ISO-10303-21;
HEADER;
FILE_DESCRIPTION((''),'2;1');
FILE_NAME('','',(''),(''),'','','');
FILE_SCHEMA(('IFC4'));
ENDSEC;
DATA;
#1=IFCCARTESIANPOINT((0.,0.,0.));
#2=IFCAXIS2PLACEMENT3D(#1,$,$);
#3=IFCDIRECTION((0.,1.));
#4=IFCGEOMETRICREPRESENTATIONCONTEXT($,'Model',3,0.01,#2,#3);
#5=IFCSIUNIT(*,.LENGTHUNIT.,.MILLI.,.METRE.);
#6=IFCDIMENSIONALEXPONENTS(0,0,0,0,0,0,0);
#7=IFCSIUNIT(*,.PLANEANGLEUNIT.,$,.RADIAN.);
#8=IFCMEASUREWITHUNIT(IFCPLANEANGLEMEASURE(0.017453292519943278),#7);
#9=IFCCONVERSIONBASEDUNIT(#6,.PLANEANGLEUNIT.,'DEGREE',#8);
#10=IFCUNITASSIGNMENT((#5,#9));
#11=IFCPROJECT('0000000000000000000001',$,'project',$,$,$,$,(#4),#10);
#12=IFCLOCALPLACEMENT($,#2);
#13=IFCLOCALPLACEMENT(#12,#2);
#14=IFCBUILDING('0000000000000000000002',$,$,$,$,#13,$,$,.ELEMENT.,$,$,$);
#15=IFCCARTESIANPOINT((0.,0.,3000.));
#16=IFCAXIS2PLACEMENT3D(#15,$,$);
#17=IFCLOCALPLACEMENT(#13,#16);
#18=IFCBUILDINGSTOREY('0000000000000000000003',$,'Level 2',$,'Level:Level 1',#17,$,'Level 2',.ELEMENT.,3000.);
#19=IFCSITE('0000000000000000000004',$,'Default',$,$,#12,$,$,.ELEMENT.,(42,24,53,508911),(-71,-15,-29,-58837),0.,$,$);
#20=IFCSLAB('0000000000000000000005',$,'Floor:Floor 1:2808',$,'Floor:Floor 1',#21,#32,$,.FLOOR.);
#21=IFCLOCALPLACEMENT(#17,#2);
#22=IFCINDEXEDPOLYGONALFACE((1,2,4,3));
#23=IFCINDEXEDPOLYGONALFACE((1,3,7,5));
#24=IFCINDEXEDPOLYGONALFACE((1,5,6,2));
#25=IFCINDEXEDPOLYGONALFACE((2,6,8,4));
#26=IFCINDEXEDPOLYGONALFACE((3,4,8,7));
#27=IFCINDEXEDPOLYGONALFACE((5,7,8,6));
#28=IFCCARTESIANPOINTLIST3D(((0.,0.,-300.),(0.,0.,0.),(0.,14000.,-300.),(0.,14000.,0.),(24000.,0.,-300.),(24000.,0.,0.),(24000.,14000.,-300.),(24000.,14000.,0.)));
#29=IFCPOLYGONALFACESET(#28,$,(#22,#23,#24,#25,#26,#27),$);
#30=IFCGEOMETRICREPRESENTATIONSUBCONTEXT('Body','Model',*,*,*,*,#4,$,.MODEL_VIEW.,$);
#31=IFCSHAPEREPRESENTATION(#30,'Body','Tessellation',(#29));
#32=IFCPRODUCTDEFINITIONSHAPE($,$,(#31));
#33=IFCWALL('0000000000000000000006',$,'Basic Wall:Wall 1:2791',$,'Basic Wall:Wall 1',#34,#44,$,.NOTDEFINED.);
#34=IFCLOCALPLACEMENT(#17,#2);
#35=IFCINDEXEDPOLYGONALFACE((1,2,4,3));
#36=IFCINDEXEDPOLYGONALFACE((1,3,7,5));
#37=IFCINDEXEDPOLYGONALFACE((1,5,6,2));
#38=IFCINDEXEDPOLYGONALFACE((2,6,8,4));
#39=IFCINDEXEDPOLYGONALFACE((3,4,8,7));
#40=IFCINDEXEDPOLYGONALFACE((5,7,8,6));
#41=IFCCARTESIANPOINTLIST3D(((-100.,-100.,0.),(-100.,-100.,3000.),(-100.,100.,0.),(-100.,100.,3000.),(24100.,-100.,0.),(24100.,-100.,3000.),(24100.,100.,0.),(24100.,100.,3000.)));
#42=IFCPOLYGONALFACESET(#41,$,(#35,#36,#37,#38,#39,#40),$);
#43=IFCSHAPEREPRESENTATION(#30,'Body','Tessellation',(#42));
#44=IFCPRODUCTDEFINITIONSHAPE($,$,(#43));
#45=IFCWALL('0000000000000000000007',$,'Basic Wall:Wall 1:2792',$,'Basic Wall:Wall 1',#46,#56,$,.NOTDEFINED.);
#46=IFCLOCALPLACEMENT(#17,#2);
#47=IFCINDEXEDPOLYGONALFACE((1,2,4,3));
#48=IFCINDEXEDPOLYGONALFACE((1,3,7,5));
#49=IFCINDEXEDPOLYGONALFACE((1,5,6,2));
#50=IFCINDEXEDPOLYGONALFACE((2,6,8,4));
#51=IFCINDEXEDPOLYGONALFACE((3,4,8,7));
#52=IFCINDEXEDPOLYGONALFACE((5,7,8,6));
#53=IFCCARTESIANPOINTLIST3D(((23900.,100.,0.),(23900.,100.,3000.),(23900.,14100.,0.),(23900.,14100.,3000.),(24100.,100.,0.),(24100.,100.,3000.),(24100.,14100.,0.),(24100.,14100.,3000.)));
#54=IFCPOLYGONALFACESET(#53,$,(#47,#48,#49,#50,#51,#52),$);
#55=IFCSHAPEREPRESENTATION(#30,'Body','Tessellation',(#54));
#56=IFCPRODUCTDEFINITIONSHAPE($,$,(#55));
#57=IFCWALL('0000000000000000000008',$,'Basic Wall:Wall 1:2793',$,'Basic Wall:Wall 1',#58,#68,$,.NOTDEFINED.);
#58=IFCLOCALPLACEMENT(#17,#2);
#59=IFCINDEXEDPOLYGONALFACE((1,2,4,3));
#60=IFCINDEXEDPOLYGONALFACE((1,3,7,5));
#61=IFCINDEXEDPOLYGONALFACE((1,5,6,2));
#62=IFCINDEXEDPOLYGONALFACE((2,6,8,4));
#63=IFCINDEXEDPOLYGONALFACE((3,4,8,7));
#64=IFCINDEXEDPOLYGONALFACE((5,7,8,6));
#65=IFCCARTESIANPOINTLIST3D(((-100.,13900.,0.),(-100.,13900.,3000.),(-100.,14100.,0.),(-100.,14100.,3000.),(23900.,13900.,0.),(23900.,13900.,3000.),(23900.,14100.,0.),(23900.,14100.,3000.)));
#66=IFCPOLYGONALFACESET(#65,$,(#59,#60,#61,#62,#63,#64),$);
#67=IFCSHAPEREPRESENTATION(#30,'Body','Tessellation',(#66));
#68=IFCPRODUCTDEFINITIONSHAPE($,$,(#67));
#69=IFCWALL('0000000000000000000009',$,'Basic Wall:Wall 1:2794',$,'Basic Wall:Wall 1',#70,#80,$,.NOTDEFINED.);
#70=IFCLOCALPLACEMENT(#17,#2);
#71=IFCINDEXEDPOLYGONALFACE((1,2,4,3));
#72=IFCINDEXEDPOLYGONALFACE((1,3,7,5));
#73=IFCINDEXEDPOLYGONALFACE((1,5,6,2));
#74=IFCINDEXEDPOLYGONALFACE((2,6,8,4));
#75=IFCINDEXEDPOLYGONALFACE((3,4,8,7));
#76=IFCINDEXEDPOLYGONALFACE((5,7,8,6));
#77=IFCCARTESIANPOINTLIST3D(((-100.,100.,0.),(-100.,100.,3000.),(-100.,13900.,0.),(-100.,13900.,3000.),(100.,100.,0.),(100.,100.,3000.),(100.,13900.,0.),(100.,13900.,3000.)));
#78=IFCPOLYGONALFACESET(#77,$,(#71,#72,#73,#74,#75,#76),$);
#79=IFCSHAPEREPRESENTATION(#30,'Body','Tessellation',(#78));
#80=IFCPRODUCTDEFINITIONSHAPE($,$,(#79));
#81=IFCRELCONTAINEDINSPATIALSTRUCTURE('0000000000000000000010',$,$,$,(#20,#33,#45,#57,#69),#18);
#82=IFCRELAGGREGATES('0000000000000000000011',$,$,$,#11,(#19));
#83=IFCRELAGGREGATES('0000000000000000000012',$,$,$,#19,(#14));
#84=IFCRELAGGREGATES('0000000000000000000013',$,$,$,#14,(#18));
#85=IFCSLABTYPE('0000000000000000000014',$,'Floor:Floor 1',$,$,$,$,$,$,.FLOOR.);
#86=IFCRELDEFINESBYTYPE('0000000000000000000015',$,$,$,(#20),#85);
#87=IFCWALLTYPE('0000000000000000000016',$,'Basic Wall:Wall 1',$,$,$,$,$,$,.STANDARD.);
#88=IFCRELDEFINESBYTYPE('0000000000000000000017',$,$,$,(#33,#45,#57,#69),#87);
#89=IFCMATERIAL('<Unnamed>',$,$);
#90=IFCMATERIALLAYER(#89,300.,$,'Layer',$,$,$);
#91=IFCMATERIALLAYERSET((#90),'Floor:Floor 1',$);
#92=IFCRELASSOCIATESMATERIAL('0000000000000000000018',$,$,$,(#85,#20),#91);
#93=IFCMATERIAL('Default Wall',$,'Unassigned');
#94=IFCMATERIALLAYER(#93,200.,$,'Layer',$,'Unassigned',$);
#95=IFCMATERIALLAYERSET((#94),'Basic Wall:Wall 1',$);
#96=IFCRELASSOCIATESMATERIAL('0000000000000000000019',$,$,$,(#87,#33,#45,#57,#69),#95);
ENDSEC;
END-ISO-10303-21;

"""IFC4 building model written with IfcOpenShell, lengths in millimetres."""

from ifc_helpers import new_model, entity, si_unit, converted_unit, direction, frame, frame_2d, origin, origin_2d_with_axis, place, context, subcontext, project, spatial, rectangle, extrude, material, layer, layer_set, layer_usage, type_object, element, save


model = new_model("IFC4")

# Units and contexts
model_context = context("Model", 3, precision=0.01, world=origin(), true_north=direction((0.0, 1.0)))
body_context = subcontext(model_context, "Body", "Model", "MODEL_VIEW")
ifc_project = project(units=[si_unit("LENGTHUNIT", "METRE", prefix="MILLI"), converted_unit("PLANEANGLEUNIT", "DEGREE", entity("IfcPlaneAngleMeasure", 0.017453292519943278), si_unit("PLANEANGLEUNIT", "RADIAN"), dimensions=[0, 0, 0, 0, 0, 0, 0])], contexts=[model_context])

# Site, building, storey
site_placement = place(None, origin())
site = spatial("IfcSite", under=ifc_project, at=site_placement, Name="Default", CompositionType="ELEMENT", RefLatitude=(42, 24, 53, 508911), RefLongitude=(-71, -15, -29, -58837), RefElevation=0.0)
building_placement = place(site_placement, origin())
building = spatial("IfcBuilding", under=site, at=building_placement, CompositionType="ELEMENT")
storey_placement = place(building_placement, frame((0.0, 0.0, 3000.0)))
storey = spatial("IfcBuildingStorey", under=building, at=storey_placement, Name="Level 2", ObjectType="Level:Level 1", LongName="Level 2", CompositionType="ELEMENT", Elevation=3000.0)

# Slab
ifc_material_1 = material(Name="<Unnamed>")
ifc_layer_1 = layer(ifc_material_1, 300.0, Name="Layer")
ifc_layer_set_1 = layer_set([ifc_layer_1], Name="Floor:Floor 1")
ifc_layer_usage_1 = layer_usage(ifc_layer_set_1, "AXIS3", "POSITIVE", 0.0)
slab_type = type_object("IfcSlabType", Name="Floor:Floor 1", PredefinedType="FLOOR", material=ifc_layer_set_1)
slab_placement = place(storey_placement, origin())
element("IfcSlab", 1, at=slab_placement, inside=storey, type_object=slab_type, material=ifc_layer_usage_1, Name="Floor:Floor 1:2808", ObjectType="Floor:Floor 1", PredefinedType="FLOOR", context=body_context, shape_type="SweptSolid", body=[
    extrude(rectangle(XDim=14000.0, YDim=24000.0, at=origin_2d_with_axis()), frame((12000.0, 7000.0, 0.0), z_axis=(0.0, 0.0, -1.0), x_axis=(0.0, 1.0, 0.0)), (0.0, 0.0, 1.0), 300.0),
])

# Walls
ifc_material_2 = material(Name="Default Wall", Category="Unassigned")
ifc_layer_2 = layer(ifc_material_2, 200.0, Name="Layer", Category="Unassigned")
ifc_layer_set_2 = layer_set([ifc_layer_2], Name="Basic Wall:Wall 1")
ifc_layer_usage_2 = layer_usage(ifc_layer_set_2, "AXIS2", "NEGATIVE", 100.0)
wall_type = type_object("IfcWallType", Name="Basic Wall:Wall 1", PredefinedType="STANDARD", material=ifc_layer_set_2)
wall_1_placement = place(storey_placement, frame((-100.0, 0.0, 0.0)))
element("IfcWall", 2, at=wall_1_placement, inside=storey, type_object=wall_type, material=ifc_layer_usage_2, Name="Basic Wall:Wall 1:2791", ObjectType="Basic Wall:Wall 1", PredefinedType="NOTDEFINED", context=body_context, shape_type="SweptSolid", body=[
    extrude(rectangle(XDim=24200.0, YDim=200.0, at=frame_2d((12100.0, 0.0), x_axis=(-1.0, 0.0))), origin(), (0.0, 0.0, 1.0), 3000.0),
])
ifc_layer_usage_3 = layer_usage(ifc_layer_set_2, "AXIS2", "NEGATIVE", 100.0)
wall_2_placement = place(storey_placement, frame((24000.0, 100.0, 0.0), z_axis=(0.0, 0.0, 1.0), x_axis=(0.0, 1.0, 0.0)))
element("IfcWall", 3, at=wall_2_placement, inside=storey, type_object=wall_type, material=ifc_layer_usage_3, Name="Basic Wall:Wall 1:2792", ObjectType="Basic Wall:Wall 1", PredefinedType="NOTDEFINED", context=body_context, shape_type="SweptSolid", body=[
    extrude(rectangle(XDim=14000.0, YDim=200.0, at=frame_2d((7000.0, 0.0), x_axis=(-1.0, 0.0))), origin(), (0.0, 0.0, 1.0), 3000.0),
])
ifc_layer_usage_4 = layer_usage(ifc_layer_set_2, "AXIS2", "NEGATIVE", 100.0)
wall_3_placement = place(storey_placement, frame((23900.0, 14000.0, 0.0), z_axis=(0.0, 0.0, 1.0), x_axis=(-1.0, 0.0, 0.0)))
element("IfcWall", 4, at=wall_3_placement, inside=storey, type_object=wall_type, material=ifc_layer_usage_4, Name="Basic Wall:Wall 1:2793", ObjectType="Basic Wall:Wall 1", PredefinedType="NOTDEFINED", context=body_context, shape_type="SweptSolid", body=[
    extrude(rectangle(XDim=24000.0, YDim=200.0, at=frame_2d((12000.0, 0.0), x_axis=(-1.0, 0.0))), origin(), (0.0, 0.0, 1.0), 3000.0),
])
ifc_layer_usage_5 = layer_usage(ifc_layer_set_2, "AXIS2", "NEGATIVE", 100.0)
wall_4_placement = place(storey_placement, frame((0.0, 13900.0, 0.0), z_axis=(0.0, 0.0, 1.0), x_axis=(0.0, -1.0, 0.0)))
element("IfcWall", 5, at=wall_4_placement, inside=storey, type_object=wall_type, material=ifc_layer_usage_5, Name="Basic Wall:Wall 1:2794", ObjectType="Basic Wall:Wall 1", PredefinedType="NOTDEFINED", context=body_context, shape_type="SweptSolid", body=[
    extrude(rectangle(XDim=13800.0, YDim=200.0, at=frame_2d((6900.0, 0.0), x_axis=(-1.0, 0.0))), origin(), (0.0, 0.0, 1.0), 3000.0),
])

save(model, "model.ifc")
